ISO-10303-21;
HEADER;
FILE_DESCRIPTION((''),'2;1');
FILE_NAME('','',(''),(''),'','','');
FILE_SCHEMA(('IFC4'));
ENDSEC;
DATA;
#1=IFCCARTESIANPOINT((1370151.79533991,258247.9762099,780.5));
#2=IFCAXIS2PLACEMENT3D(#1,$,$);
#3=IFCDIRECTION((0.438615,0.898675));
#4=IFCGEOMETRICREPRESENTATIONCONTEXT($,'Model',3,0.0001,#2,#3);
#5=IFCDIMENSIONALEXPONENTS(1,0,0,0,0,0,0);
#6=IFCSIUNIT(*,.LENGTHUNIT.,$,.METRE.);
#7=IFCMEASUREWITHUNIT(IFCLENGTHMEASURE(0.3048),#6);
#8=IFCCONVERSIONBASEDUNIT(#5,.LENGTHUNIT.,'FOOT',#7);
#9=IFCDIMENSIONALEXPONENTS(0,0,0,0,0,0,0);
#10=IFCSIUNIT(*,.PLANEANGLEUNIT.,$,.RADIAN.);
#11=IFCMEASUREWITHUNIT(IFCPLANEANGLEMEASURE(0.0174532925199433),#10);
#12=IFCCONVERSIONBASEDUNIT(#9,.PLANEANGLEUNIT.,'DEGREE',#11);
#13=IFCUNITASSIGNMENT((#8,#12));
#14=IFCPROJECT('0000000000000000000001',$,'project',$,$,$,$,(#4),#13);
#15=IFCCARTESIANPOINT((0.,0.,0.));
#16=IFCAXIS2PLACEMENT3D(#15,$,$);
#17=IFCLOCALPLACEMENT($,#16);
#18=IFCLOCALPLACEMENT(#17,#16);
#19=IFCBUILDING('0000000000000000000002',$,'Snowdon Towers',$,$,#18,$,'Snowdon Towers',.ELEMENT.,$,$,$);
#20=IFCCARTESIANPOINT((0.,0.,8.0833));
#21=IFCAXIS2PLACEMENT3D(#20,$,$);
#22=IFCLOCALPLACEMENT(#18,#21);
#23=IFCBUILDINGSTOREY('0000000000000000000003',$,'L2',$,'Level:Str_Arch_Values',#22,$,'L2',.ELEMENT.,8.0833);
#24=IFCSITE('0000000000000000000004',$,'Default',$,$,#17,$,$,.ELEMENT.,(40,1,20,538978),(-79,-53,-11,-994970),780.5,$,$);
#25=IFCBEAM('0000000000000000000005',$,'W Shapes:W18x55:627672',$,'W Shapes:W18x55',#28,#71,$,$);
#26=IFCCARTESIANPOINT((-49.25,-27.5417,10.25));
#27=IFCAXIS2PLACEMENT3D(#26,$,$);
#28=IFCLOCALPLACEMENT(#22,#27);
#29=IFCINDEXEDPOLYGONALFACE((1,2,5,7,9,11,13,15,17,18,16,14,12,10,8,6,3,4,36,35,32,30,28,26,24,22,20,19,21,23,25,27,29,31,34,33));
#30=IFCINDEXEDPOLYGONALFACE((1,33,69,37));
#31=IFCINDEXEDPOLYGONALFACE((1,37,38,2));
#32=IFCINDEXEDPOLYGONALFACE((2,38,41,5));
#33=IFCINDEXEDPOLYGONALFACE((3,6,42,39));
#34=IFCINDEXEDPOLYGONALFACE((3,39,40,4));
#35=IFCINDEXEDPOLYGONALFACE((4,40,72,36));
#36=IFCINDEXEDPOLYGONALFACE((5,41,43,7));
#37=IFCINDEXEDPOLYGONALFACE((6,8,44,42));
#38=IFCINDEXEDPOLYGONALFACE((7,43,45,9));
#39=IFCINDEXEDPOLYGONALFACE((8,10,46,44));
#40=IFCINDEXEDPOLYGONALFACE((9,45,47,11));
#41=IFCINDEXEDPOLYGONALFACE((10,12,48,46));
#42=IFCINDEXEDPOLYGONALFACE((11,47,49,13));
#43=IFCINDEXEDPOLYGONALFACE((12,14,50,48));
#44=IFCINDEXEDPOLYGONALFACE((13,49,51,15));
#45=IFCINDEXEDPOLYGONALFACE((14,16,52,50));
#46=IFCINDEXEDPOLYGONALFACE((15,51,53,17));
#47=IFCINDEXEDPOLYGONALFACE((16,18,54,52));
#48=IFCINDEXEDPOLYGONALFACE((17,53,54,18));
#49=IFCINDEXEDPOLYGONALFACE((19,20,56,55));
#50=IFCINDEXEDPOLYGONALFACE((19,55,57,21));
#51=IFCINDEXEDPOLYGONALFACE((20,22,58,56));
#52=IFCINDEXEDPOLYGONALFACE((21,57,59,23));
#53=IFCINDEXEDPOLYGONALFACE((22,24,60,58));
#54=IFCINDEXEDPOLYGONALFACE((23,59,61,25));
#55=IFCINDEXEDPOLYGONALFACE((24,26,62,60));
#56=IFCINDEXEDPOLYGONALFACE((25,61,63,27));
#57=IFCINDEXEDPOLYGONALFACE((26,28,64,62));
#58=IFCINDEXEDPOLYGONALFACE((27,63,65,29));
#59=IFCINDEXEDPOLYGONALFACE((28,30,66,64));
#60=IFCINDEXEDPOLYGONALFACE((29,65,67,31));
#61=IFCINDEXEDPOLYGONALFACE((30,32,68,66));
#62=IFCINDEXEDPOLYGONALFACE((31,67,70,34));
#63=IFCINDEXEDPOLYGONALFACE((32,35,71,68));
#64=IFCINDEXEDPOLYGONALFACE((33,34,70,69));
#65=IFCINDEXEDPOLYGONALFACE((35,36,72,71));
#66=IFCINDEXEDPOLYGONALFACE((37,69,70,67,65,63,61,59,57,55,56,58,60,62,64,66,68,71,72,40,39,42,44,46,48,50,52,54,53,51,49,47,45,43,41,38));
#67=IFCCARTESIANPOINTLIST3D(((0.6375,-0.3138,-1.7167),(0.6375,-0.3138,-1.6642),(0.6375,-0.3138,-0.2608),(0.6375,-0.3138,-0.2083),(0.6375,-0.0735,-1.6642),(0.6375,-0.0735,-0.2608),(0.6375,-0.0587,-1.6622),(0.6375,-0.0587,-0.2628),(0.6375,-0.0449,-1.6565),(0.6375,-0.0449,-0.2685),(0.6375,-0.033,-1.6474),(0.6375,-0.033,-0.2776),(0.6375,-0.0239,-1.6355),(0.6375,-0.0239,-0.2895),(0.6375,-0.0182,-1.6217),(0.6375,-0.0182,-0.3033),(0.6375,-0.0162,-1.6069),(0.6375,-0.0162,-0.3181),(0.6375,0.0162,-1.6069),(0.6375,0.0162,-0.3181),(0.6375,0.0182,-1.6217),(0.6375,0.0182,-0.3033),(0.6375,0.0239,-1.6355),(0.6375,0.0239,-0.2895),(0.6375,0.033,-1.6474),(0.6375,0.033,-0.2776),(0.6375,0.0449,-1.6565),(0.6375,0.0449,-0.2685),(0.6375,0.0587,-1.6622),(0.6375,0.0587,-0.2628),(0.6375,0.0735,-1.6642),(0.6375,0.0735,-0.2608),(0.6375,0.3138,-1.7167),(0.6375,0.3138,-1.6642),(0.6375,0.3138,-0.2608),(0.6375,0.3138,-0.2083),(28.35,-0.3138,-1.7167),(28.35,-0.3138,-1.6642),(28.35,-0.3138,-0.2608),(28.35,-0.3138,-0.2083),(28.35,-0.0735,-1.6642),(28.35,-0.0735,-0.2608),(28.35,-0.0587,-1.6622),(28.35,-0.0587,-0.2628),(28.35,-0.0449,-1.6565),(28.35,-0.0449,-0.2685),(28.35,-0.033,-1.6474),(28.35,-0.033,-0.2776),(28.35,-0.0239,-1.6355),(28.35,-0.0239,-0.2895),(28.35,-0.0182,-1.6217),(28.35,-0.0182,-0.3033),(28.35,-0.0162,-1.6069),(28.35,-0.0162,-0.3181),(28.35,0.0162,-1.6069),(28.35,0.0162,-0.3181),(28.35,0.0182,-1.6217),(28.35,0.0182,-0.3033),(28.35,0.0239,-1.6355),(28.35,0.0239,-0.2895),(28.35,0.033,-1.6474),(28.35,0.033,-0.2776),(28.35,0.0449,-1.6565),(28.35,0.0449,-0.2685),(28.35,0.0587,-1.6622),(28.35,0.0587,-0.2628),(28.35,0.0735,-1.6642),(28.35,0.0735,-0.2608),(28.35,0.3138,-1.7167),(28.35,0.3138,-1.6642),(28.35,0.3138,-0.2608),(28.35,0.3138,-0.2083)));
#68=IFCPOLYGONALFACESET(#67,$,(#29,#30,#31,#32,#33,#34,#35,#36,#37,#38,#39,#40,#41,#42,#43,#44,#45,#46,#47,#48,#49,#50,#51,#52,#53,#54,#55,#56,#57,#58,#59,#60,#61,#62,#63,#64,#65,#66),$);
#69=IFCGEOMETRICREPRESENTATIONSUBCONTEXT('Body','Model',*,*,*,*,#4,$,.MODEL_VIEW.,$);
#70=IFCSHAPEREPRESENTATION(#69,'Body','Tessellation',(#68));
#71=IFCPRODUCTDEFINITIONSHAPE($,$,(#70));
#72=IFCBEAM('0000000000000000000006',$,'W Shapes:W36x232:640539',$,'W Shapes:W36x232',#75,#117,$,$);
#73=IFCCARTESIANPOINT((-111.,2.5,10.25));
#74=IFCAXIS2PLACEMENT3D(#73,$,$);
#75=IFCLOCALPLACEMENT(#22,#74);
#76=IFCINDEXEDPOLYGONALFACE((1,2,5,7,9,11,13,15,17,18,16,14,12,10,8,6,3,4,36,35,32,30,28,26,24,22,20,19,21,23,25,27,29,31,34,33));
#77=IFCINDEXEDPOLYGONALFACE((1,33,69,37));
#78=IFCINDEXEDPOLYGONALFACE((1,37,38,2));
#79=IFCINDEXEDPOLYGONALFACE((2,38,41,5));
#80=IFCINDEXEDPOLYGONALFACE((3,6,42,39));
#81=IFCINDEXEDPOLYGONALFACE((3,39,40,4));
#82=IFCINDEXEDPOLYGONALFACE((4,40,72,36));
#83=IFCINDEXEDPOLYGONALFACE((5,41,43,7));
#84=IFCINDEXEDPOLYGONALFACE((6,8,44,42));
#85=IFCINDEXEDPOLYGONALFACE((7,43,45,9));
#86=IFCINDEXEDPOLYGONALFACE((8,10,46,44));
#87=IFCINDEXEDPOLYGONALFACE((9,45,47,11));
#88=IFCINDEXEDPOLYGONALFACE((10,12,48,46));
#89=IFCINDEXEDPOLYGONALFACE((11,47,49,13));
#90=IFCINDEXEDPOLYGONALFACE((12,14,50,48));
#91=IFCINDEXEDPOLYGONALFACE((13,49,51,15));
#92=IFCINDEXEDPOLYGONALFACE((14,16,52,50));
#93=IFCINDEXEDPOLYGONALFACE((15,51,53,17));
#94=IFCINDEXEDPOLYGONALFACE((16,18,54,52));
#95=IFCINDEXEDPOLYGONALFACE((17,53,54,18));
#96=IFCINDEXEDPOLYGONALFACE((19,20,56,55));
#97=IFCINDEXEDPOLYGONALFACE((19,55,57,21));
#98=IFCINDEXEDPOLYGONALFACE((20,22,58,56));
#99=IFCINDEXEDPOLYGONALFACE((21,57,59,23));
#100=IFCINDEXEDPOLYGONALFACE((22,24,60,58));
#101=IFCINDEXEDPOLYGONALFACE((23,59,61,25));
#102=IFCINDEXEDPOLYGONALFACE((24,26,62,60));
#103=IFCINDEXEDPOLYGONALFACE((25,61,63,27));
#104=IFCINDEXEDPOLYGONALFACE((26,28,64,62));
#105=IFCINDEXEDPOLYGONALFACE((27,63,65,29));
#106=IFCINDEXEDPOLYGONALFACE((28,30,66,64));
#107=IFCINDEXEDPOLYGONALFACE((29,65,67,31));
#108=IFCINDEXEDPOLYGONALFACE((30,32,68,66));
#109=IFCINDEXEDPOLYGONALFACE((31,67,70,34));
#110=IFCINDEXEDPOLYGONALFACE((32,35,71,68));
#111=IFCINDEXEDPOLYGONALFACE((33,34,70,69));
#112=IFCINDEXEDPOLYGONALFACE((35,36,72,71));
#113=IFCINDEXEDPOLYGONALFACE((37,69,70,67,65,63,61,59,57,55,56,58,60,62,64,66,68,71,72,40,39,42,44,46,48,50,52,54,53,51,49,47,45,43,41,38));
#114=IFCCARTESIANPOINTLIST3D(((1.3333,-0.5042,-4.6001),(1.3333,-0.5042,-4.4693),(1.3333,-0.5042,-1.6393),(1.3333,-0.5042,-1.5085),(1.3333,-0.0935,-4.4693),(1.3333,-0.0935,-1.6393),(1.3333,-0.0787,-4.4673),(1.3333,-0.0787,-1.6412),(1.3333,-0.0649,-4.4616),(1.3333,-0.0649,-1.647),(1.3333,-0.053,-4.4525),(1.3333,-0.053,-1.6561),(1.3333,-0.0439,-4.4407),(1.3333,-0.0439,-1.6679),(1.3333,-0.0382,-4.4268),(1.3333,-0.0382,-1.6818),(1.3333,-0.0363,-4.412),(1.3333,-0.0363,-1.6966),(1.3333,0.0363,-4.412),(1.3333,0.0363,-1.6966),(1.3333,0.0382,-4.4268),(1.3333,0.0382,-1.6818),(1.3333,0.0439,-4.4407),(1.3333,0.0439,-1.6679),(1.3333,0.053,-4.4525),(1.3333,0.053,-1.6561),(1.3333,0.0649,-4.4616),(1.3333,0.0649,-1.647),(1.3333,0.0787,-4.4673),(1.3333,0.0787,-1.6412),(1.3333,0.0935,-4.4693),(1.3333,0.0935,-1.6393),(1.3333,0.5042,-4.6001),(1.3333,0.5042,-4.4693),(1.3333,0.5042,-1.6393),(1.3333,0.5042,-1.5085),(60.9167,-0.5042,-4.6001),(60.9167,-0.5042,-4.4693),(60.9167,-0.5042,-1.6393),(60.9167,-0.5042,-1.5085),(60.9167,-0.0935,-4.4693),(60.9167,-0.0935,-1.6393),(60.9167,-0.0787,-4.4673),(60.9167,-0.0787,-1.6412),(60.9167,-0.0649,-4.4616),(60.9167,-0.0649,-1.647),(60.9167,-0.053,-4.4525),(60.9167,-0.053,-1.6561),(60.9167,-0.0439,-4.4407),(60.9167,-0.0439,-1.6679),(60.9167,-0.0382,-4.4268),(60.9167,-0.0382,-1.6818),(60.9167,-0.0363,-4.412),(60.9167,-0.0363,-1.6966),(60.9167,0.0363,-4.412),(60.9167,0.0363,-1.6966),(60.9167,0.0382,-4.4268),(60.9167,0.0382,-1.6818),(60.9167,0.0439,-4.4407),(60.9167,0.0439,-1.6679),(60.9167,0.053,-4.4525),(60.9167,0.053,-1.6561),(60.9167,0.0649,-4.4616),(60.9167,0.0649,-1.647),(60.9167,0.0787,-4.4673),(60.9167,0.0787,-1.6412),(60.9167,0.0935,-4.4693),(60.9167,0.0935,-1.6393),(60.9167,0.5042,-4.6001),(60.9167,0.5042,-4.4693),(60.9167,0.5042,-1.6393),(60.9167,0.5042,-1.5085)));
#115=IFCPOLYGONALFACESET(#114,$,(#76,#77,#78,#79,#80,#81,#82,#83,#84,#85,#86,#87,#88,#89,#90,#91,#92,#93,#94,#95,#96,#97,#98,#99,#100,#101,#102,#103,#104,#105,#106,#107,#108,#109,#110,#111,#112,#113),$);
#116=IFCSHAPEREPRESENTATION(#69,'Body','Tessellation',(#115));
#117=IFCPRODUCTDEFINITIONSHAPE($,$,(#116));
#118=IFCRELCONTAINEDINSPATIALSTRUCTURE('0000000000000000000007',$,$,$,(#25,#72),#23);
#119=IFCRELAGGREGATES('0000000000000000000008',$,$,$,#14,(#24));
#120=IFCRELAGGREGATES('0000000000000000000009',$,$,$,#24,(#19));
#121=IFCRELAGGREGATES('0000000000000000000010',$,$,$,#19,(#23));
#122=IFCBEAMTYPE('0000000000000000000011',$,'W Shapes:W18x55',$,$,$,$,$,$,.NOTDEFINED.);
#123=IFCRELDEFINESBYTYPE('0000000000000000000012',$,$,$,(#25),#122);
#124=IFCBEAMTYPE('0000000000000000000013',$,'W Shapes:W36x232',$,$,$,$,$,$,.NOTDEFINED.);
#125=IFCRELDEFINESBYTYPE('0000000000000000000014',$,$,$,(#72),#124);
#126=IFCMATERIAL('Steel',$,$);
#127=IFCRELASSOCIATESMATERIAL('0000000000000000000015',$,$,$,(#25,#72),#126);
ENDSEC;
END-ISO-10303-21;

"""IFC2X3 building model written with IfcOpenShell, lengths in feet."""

from ifc_helpers import new_model, entity, si_unit, converted_unit, direction, frame, frame_2d, origin, place, context, subcontext, project, spatial, i_section, extrude, material, type_object, element, save


model = new_model("IFC2X3")

# Units and contexts
model_context = context("Model", 3, precision=0.0001, world=frame((1370151.79533991, 258247.9762099, 780.5)), true_north=direction((0.438615, 0.898675)))
body_context = subcontext(model_context, "Body", "Model", "MODEL_VIEW")
ifc_project = project(units=[converted_unit("LENGTHUNIT", "FOOT", entity("IfcLengthMeasure", 0.3048), si_unit("LENGTHUNIT", "METRE"), dimensions=[1, 0, 0, 0, 0, 0, 0]), converted_unit("PLANEANGLEUNIT", "DEGREE", entity("IfcPlaneAngleMeasure", 0.0174532925199433), si_unit("PLANEANGLEUNIT", "RADIAN"), dimensions=[0, 0, 0, 0, 0, 0, 0])], contexts=[model_context])

# Site, building, storey
site_placement = place(None, origin())
site = spatial("IfcSite", under=ifc_project, at=site_placement, Name="Default", CompositionType="ELEMENT", RefLatitude=(40, 1, 20, 538978), RefLongitude=(-79, -53, -11, -994970), RefElevation=780.5)
building_placement = place(site_placement, origin())
building = spatial("IfcBuilding", under=site, at=building_placement, Name="Snowdon Towers", LongName="Snowdon Towers", CompositionType="ELEMENT")
storey_placement = place(building_placement, frame((0.0, 0.0, 8.0833)))
storey = spatial("IfcBuildingStorey", under=building, at=storey_placement, Name="L2", ObjectType="Level:Str_Arch_Values", LongName="L2", CompositionType="ELEMENT", Elevation=8.0833)

# Beam
ifc_material_1 = material(Name="Steel")
beam_type_1 = type_object("IfcBeamType", Name="W Shapes:W18x55", PredefinedType="NOTDEFINED")
beam_1_placement = place(storey_placement, frame((-49.25, -27.5417, 10.25)))
element("IfcBeam", 1, at=beam_1_placement, inside=storey, type_object=beam_type_1, material=ifc_material_1, Name="W Shapes:W18x55:627672", ObjectType="W Shapes:W18x55", context=body_context, shape_type="SweptSolid", body=[
    extrude(i_section(OverallWidth=0.6275, OverallDepth=1.5083, WebThickness=0.0325, FlangeThickness=0.0525, FilletRadius=0.0573, at=frame_2d((0.0, 0.0), x_axis=(0.0, 1.0))), frame((0.6375, 0.0, -0.9625), z_axis=(1.0, 0.0, 0.0), x_axis=(0.0, 0.0, -1.0)), (0.0, 0.0, 1.0), 27.7125),
])

# Beam
beam_type_2 = type_object("IfcBeamType", Name="W Shapes:W36x232", PredefinedType="NOTDEFINED")
beam_2_placement = place(storey_placement, frame((-111.0, 2.5, 10.25)))
element("IfcBeam", 2, at=beam_2_placement, inside=storey, type_object=beam_type_2, material=ifc_material_1, Name="W Shapes:W36x232:640539", ObjectType="W Shapes:W36x232", context=body_context, shape_type="SweptSolid", body=[
    extrude(i_section(OverallWidth=1.0083, OverallDepth=3.0917, WebThickness=0.0725, FlangeThickness=0.1308, FilletRadius=0.0573, at=frame_2d((0.0, 0.0), x_axis=(0.0, 1.0))), frame((1.3333, 0.0, -3.0543), z_axis=(1.0, 0.0, 0.0), x_axis=(0.0, 0.0, -1.0)), (0.0, 0.0, 1.0), 59.5833),
])

save(model, "model.ifc")
